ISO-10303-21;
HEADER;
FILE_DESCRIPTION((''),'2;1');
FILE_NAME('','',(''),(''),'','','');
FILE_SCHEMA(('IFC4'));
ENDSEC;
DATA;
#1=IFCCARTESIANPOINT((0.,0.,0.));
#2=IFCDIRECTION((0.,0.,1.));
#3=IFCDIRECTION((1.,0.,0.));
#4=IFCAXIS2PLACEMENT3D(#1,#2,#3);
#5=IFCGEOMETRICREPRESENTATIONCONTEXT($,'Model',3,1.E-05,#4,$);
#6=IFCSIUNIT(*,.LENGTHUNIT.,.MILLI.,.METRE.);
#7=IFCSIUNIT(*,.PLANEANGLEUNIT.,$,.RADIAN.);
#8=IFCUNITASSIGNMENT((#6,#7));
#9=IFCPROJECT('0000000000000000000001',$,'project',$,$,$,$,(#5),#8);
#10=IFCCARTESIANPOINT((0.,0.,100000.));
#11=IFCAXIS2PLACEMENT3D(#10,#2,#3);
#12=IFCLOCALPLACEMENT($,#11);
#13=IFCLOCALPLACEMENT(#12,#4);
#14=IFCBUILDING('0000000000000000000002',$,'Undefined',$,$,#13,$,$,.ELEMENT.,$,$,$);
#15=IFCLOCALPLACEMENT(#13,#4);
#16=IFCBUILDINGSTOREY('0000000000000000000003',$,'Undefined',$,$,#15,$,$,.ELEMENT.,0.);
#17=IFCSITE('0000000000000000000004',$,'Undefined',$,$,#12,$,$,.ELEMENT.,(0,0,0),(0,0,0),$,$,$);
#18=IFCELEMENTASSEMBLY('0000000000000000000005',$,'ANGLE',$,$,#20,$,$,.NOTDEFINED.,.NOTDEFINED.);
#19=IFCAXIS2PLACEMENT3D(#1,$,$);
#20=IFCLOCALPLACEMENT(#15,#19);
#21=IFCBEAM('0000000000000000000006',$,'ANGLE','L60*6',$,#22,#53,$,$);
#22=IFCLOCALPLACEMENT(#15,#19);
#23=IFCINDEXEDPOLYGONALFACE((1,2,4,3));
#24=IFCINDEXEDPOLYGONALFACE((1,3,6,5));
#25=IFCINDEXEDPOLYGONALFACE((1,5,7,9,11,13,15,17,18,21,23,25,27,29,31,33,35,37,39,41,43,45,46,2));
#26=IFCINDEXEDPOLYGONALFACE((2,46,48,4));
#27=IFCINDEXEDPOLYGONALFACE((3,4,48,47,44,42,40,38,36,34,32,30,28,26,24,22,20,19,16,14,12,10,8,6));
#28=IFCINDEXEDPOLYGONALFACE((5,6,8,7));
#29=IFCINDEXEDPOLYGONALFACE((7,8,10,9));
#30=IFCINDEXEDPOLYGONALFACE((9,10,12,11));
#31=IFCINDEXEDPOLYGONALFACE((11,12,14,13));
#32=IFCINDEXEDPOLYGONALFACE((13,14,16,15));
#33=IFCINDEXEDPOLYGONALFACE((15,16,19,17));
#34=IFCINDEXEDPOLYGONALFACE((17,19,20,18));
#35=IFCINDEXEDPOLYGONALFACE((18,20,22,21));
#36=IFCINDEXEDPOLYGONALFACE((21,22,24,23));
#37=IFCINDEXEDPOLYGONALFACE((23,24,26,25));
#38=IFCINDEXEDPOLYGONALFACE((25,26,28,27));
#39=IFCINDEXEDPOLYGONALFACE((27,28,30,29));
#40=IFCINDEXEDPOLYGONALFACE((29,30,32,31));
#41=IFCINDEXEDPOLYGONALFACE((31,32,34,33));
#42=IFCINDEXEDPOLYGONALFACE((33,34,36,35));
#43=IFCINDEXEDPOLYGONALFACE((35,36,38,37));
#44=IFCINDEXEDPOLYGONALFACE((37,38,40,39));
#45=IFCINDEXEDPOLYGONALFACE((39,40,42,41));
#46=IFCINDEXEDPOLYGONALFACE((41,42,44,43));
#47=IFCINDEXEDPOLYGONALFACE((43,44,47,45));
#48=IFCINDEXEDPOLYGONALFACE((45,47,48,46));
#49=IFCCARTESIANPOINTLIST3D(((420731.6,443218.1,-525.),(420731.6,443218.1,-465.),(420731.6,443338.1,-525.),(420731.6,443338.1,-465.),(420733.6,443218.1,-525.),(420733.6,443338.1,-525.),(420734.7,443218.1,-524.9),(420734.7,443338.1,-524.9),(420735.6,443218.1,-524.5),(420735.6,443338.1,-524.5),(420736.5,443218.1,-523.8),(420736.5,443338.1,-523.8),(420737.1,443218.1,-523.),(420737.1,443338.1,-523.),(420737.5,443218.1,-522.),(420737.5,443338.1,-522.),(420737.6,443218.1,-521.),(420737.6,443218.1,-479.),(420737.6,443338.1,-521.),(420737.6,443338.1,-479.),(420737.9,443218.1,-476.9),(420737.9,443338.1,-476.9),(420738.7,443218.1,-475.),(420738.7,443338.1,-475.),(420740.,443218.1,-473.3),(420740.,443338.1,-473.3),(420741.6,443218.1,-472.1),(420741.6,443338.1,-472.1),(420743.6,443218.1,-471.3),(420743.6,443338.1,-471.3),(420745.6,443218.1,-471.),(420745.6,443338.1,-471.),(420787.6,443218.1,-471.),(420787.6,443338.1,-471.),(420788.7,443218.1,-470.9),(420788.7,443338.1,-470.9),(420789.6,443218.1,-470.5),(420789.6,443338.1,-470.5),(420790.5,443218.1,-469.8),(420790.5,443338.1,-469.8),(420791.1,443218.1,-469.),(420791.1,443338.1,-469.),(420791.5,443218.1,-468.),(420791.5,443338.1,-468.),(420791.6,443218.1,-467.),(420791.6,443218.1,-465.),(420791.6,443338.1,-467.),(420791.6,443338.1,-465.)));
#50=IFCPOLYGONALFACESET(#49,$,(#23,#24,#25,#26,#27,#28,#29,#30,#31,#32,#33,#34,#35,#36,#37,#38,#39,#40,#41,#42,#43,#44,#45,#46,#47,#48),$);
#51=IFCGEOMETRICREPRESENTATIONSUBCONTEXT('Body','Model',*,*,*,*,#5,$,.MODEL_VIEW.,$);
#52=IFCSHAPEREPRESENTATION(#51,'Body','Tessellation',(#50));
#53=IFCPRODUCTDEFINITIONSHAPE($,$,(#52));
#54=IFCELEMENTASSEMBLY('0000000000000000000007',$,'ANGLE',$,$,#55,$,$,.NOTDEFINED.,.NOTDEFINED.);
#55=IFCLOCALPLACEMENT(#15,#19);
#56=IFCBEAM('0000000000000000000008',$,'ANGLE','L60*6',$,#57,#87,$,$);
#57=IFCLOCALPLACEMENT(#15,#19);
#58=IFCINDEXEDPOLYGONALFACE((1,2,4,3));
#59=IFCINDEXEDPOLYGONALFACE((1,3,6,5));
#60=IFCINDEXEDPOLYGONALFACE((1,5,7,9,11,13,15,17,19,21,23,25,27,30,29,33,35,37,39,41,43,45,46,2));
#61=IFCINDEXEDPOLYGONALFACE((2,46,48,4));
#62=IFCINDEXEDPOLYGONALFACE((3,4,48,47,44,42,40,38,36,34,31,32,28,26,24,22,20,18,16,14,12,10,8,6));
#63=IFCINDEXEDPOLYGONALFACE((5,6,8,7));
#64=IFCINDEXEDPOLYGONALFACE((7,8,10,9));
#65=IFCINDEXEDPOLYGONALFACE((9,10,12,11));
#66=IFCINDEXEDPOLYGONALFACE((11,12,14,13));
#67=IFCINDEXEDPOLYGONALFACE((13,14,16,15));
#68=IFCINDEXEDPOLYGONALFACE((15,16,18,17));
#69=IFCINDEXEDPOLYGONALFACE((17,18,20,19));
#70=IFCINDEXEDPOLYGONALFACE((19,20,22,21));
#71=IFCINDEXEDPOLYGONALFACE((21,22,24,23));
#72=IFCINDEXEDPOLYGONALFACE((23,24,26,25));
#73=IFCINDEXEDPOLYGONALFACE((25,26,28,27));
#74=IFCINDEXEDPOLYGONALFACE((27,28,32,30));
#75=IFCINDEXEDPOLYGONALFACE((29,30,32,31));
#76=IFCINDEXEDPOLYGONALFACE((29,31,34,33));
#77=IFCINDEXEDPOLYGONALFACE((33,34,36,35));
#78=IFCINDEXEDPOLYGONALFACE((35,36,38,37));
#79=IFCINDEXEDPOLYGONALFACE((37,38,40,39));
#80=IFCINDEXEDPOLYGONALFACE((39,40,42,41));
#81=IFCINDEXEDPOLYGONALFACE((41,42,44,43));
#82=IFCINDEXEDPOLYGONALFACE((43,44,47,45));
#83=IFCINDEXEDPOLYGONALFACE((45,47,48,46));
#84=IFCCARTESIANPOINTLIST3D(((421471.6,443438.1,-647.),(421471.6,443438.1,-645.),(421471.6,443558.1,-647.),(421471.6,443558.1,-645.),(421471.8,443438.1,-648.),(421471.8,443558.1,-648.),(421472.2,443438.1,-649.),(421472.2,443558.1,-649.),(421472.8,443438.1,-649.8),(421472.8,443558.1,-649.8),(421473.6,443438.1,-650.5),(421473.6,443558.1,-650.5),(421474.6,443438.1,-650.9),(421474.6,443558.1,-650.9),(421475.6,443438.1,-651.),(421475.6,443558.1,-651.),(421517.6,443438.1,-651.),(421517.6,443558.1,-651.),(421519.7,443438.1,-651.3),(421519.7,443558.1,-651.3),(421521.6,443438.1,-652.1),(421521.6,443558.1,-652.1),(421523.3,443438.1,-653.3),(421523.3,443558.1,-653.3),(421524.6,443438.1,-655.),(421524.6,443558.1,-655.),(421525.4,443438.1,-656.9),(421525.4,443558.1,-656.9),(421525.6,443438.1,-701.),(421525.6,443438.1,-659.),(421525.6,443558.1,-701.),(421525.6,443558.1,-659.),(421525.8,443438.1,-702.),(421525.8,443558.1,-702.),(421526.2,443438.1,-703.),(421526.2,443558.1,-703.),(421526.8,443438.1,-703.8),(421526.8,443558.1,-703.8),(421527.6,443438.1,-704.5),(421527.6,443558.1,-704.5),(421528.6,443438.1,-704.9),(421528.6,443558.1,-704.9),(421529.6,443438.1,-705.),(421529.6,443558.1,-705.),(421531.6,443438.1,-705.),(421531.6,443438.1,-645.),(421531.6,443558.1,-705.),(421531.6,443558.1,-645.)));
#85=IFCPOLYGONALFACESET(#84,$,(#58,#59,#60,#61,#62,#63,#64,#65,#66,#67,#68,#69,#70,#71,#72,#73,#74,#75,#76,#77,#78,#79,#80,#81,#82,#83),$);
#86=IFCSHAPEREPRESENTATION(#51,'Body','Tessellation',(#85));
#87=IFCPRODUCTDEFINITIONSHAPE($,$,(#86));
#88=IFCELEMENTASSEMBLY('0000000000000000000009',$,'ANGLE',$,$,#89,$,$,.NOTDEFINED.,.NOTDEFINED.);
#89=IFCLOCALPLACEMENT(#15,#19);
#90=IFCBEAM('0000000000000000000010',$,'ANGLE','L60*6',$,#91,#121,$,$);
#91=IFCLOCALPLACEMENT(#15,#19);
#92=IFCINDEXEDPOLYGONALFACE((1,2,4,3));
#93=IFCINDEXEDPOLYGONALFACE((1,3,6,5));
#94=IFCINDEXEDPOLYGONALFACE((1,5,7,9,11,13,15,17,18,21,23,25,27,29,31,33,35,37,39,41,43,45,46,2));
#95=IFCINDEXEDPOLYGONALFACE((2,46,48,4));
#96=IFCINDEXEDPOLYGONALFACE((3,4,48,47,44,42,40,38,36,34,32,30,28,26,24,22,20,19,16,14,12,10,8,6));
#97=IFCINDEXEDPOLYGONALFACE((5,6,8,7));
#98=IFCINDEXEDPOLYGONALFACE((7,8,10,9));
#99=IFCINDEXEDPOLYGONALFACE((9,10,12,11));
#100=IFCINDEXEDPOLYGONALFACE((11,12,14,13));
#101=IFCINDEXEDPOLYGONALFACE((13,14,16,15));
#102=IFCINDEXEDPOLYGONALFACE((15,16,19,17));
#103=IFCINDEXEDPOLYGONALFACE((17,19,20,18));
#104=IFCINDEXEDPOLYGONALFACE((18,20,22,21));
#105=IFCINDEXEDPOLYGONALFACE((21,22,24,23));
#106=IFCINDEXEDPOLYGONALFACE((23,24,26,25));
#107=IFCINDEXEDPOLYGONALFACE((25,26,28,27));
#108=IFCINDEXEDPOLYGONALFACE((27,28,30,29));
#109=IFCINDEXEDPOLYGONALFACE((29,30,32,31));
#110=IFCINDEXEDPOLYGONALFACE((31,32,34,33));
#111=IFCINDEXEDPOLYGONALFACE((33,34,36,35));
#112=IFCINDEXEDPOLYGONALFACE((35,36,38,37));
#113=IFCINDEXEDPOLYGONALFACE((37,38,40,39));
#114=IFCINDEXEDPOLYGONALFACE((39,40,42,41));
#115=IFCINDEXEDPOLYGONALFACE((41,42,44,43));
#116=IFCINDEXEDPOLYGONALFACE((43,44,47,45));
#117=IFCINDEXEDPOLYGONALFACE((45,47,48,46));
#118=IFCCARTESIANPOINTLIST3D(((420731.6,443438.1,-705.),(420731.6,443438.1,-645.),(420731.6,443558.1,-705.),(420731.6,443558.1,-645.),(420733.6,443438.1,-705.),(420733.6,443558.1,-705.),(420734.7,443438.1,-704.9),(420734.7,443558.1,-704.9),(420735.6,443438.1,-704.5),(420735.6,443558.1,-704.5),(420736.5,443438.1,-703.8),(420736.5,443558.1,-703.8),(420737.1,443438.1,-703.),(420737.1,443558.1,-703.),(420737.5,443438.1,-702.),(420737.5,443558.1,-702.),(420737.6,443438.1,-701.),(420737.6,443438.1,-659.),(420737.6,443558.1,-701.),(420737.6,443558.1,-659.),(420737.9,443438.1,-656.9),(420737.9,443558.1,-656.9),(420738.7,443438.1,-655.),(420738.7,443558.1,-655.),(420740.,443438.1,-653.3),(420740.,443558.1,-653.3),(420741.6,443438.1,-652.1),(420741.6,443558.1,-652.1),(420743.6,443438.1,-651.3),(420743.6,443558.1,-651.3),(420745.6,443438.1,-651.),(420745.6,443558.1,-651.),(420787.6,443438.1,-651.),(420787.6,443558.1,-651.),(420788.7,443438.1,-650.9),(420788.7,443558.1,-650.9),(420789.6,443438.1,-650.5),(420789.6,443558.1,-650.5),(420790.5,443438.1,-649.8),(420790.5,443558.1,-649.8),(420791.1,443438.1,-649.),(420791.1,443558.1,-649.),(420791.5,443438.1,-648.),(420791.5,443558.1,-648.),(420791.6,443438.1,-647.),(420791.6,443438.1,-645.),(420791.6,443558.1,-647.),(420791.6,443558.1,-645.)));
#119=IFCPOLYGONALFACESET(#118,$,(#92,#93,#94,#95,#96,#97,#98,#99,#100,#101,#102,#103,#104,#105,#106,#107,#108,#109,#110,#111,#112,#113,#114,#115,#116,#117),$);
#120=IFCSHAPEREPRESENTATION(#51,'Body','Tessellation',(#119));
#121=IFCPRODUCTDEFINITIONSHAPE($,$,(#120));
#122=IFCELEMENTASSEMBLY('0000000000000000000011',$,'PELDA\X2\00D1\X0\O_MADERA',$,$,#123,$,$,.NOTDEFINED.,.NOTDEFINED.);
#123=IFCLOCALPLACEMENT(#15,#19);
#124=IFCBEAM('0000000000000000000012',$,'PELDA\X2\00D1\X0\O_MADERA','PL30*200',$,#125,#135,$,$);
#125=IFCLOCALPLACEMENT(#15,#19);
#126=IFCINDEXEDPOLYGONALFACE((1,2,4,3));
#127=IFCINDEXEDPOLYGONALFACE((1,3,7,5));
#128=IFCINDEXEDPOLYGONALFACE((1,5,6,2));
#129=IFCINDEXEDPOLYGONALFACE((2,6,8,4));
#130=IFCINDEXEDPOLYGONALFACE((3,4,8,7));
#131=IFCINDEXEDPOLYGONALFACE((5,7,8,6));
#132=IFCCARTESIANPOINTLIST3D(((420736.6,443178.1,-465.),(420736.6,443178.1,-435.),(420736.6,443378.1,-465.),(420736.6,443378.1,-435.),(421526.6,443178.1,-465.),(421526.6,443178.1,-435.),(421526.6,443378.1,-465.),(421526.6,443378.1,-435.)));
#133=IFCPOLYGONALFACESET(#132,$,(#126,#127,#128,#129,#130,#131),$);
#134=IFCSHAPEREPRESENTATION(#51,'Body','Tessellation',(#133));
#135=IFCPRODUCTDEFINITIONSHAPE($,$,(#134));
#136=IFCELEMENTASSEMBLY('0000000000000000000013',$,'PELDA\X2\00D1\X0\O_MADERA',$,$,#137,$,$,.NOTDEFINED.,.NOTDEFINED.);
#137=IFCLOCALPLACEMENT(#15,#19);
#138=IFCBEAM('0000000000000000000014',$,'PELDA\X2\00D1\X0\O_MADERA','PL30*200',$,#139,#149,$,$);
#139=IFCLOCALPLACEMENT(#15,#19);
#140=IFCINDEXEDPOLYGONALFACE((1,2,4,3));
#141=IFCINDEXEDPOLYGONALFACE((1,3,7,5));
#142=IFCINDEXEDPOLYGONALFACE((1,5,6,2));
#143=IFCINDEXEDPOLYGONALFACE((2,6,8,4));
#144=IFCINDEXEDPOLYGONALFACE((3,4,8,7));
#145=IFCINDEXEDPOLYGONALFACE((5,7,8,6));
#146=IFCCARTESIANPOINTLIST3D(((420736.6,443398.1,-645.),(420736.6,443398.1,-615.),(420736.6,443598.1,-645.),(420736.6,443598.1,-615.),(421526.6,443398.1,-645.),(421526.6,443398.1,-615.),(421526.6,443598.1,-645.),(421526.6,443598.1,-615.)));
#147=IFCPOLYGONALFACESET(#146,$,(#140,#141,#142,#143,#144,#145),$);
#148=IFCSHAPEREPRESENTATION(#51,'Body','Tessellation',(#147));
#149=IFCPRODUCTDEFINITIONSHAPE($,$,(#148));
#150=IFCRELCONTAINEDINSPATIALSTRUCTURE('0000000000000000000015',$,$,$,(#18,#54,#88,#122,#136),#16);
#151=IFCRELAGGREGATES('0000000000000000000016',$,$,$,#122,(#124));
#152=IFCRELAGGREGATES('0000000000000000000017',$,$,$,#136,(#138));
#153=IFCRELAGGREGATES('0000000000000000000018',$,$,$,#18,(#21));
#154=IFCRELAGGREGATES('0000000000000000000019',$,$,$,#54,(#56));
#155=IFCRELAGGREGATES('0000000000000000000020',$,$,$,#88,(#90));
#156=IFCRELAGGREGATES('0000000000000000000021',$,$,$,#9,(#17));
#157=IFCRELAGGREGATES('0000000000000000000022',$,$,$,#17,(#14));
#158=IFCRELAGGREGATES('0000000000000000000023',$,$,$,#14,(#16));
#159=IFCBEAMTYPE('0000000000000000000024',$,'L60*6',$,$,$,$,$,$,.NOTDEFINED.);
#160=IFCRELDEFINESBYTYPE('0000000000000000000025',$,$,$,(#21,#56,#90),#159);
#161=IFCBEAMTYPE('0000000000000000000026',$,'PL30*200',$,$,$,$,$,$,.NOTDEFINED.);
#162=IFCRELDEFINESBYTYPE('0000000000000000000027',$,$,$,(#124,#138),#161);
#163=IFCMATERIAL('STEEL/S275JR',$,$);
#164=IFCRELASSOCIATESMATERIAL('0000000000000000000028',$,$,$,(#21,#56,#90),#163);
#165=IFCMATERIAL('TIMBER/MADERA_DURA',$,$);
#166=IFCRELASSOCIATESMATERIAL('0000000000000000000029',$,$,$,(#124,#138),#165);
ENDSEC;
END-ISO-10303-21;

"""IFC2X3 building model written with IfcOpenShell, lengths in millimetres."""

from ifc_helpers import new_model, si_unit, frame, origin_with_axes, origin_2d_with_axis, place, context, subcontext, project, spatial, rectangle, l_section, extrude, material, type_object, element, aggregate, save


model = new_model("IFC2X3")

# Units and contexts
model_context = context("Model", 3, precision=1e-05, world=origin_with_axes())
body_context = subcontext(model_context, "Body", "Model", "MODEL_VIEW")
ifc_project = project(units=[si_unit("LENGTHUNIT", "METRE", prefix="MILLI"), si_unit("PLANEANGLEUNIT", "RADIAN")], contexts=[model_context])

# Site, building, storey
site_placement = place(None, frame((0.0, 0.0, 100000.0), z_axis=(0.0, 0.0, 1.0), x_axis=(1.0, 0.0, 0.0)))
site = spatial("IfcSite", under=ifc_project, at=site_placement, Name="Undefined", CompositionType="ELEMENT", RefLatitude=(0, 0, 0), RefLongitude=(0, 0, 0))
building_placement = place(site_placement, origin_with_axes())
building = spatial("IfcBuilding", under=site, at=building_placement, Name="Undefined", CompositionType="ELEMENT")
storey_placement = place(building_placement, origin_with_axes())
storey = spatial("IfcBuildingStorey", under=building, at=storey_placement, Name="Undefined", CompositionType="ELEMENT", Elevation=0.0)

# Shared definitions
ifc_material_1 = material(Name="STEEL/S275JR")

# Element assemblies, beams
beam_type_1 = type_object("IfcBeamType", Name="L60*6", PredefinedType="NOTDEFINED")
assembly_1_placement = place(storey_placement, origin_with_axes())
assembly_1 = element("IfcElementAssembly", 1, at=assembly_1_placement, inside=storey, Name="ANGLE", AssemblyPlace="NOTDEFINED", PredefinedType="NOTDEFINED")
beam_1_placement = place(assembly_1_placement, frame((420761.6, 443218.1, -495.0), z_axis=(1.0, 0.000001, 0.0), x_axis=(-0.000001, 1.0, 0.0)))
beam_1 = element("IfcBeam", 2, at=beam_1_placement, type_object=beam_type_1, material=ifc_material_1, Name="ANGLE", Description="L60*6", context=body_context, shape_type="SweptSolid", body=[
    extrude(l_section(Depth=60.0, Width=60.0, Thickness=6.0, FilletRadius=8.0, EdgeRadius=4.0, at=origin_2d_with_axis()), frame((120.0, 0.0, 0.0), z_axis=(-1.0, 0.0, 0.0), x_axis=(0.0, -1.0, 0.0)), (0.0, 0.0, 1.0), 120.0),
])
assembly_2_placement = place(storey_placement, origin_with_axes())
assembly_2 = element("IfcElementAssembly", 3, at=assembly_2_placement, inside=storey, Name="ANGLE", AssemblyPlace="NOTDEFINED", PredefinedType="NOTDEFINED")
beam_2_placement = place(assembly_2_placement, frame((421501.6, 443558.1, -675.0), z_axis=(-1.0, -0.000001, 0.0), x_axis=(0.000001, -1.0, 0.0)))
beam_2 = element("IfcBeam", 4, at=beam_2_placement, type_object=beam_type_1, material=ifc_material_1, Name="ANGLE", Description="L60*6", context=body_context, shape_type="SweptSolid", body=[
    extrude(l_section(Depth=60.0, Width=60.0, Thickness=6.0, FilletRadius=8.0, EdgeRadius=4.0, at=origin_2d_with_axis()), frame((120.0, 0.0, 0.0), z_axis=(-1.0, 0.0, 0.0), x_axis=(0.0, -1.0, 0.0)), (0.0, 0.0, 1.0), 120.0),
])
assembly_3_placement = place(storey_placement, origin_with_axes())
assembly_3 = element("IfcElementAssembly", 5, at=assembly_3_placement, inside=storey, Name="ANGLE", AssemblyPlace="NOTDEFINED", PredefinedType="NOTDEFINED")
beam_3_placement = place(assembly_3_placement, frame((420761.6, 443438.1, -675.0), z_axis=(1.0, 0.000001, 0.0), x_axis=(-0.000001, 1.0, 0.0)))
beam_3 = element("IfcBeam", 6, at=beam_3_placement, type_object=beam_type_1, material=ifc_material_1, Name="ANGLE", Description="L60*6", context=body_context, shape_type="SweptSolid", body=[
    extrude(l_section(Depth=60.0, Width=60.0, Thickness=6.0, FilletRadius=8.0, EdgeRadius=4.0, at=origin_2d_with_axis()), frame((120.0, 0.0, 0.0), z_axis=(-1.0, 0.0, 0.0), x_axis=(0.0, -1.0, 0.0)), (0.0, 0.0, 1.0), 120.0),
])
assembly_4_placement = place(storey_placement, origin_with_axes())
assembly_4 = element("IfcElementAssembly", 7, at=assembly_4_placement, inside=storey, Name="PELDAÑO_MADERA", AssemblyPlace="NOTDEFINED", PredefinedType="NOTDEFINED")
ifc_material_2 = material(Name="TIMBER/MADERA_DURA")
beam_type_2 = type_object("IfcBeamType", Name="PL30*200", PredefinedType="NOTDEFINED")
beam_4_placement = place(assembly_4_placement, frame((420736.6, 443278.1, -450.0), z_axis=(0.000001, -1.0, 0.0), x_axis=(1.0, 0.000001, 0.0)))
beam_4 = element("IfcBeam", 8, at=beam_4_placement, type_object=beam_type_2, material=ifc_material_2, Name="PELDAÑO_MADERA", Description="PL30*200", context=body_context, shape_type="SweptSolid", body=[
    extrude(rectangle(XDim=30.0, YDim=200.0, at=origin_2d_with_axis()), frame((790.0, 0.0, 0.0), z_axis=(-1.0, 0.0, 0.0), x_axis=(0.0, -1.0, 0.0)), (0.0, 0.0, 1.0), 790.0),
])
aggregate(assembly_4, [beam_4])
assembly_5_placement = place(storey_placement, origin_with_axes())
assembly_5 = element("IfcElementAssembly", 9, at=assembly_5_placement, inside=storey, Name="PELDAÑO_MADERA", AssemblyPlace="NOTDEFINED", PredefinedType="NOTDEFINED")
beam_5_placement = place(assembly_5_placement, frame((420736.6, 443498.1, -630.0), z_axis=(0.000001, -1.0, 0.0), x_axis=(1.0, 0.000001, 0.0)))
beam_5 = element("IfcBeam", 10, at=beam_5_placement, type_object=beam_type_2, material=ifc_material_2, Name="PELDAÑO_MADERA", Description="PL30*200", context=body_context, shape_type="SweptSolid", body=[
    extrude(rectangle(XDim=30.0, YDim=200.0, at=origin_2d_with_axis()), frame((790.0, 0.0, 0.0), z_axis=(-1.0, 0.0, 0.0), x_axis=(0.0, -1.0, 0.0)), (0.0, 0.0, 1.0), 790.0),
])
aggregate(assembly_5, [beam_5])

aggregate(assembly_1, [beam_1])
aggregate(assembly_2, [beam_2])
aggregate(assembly_3, [beam_3])

save(model, "model.ifc")
